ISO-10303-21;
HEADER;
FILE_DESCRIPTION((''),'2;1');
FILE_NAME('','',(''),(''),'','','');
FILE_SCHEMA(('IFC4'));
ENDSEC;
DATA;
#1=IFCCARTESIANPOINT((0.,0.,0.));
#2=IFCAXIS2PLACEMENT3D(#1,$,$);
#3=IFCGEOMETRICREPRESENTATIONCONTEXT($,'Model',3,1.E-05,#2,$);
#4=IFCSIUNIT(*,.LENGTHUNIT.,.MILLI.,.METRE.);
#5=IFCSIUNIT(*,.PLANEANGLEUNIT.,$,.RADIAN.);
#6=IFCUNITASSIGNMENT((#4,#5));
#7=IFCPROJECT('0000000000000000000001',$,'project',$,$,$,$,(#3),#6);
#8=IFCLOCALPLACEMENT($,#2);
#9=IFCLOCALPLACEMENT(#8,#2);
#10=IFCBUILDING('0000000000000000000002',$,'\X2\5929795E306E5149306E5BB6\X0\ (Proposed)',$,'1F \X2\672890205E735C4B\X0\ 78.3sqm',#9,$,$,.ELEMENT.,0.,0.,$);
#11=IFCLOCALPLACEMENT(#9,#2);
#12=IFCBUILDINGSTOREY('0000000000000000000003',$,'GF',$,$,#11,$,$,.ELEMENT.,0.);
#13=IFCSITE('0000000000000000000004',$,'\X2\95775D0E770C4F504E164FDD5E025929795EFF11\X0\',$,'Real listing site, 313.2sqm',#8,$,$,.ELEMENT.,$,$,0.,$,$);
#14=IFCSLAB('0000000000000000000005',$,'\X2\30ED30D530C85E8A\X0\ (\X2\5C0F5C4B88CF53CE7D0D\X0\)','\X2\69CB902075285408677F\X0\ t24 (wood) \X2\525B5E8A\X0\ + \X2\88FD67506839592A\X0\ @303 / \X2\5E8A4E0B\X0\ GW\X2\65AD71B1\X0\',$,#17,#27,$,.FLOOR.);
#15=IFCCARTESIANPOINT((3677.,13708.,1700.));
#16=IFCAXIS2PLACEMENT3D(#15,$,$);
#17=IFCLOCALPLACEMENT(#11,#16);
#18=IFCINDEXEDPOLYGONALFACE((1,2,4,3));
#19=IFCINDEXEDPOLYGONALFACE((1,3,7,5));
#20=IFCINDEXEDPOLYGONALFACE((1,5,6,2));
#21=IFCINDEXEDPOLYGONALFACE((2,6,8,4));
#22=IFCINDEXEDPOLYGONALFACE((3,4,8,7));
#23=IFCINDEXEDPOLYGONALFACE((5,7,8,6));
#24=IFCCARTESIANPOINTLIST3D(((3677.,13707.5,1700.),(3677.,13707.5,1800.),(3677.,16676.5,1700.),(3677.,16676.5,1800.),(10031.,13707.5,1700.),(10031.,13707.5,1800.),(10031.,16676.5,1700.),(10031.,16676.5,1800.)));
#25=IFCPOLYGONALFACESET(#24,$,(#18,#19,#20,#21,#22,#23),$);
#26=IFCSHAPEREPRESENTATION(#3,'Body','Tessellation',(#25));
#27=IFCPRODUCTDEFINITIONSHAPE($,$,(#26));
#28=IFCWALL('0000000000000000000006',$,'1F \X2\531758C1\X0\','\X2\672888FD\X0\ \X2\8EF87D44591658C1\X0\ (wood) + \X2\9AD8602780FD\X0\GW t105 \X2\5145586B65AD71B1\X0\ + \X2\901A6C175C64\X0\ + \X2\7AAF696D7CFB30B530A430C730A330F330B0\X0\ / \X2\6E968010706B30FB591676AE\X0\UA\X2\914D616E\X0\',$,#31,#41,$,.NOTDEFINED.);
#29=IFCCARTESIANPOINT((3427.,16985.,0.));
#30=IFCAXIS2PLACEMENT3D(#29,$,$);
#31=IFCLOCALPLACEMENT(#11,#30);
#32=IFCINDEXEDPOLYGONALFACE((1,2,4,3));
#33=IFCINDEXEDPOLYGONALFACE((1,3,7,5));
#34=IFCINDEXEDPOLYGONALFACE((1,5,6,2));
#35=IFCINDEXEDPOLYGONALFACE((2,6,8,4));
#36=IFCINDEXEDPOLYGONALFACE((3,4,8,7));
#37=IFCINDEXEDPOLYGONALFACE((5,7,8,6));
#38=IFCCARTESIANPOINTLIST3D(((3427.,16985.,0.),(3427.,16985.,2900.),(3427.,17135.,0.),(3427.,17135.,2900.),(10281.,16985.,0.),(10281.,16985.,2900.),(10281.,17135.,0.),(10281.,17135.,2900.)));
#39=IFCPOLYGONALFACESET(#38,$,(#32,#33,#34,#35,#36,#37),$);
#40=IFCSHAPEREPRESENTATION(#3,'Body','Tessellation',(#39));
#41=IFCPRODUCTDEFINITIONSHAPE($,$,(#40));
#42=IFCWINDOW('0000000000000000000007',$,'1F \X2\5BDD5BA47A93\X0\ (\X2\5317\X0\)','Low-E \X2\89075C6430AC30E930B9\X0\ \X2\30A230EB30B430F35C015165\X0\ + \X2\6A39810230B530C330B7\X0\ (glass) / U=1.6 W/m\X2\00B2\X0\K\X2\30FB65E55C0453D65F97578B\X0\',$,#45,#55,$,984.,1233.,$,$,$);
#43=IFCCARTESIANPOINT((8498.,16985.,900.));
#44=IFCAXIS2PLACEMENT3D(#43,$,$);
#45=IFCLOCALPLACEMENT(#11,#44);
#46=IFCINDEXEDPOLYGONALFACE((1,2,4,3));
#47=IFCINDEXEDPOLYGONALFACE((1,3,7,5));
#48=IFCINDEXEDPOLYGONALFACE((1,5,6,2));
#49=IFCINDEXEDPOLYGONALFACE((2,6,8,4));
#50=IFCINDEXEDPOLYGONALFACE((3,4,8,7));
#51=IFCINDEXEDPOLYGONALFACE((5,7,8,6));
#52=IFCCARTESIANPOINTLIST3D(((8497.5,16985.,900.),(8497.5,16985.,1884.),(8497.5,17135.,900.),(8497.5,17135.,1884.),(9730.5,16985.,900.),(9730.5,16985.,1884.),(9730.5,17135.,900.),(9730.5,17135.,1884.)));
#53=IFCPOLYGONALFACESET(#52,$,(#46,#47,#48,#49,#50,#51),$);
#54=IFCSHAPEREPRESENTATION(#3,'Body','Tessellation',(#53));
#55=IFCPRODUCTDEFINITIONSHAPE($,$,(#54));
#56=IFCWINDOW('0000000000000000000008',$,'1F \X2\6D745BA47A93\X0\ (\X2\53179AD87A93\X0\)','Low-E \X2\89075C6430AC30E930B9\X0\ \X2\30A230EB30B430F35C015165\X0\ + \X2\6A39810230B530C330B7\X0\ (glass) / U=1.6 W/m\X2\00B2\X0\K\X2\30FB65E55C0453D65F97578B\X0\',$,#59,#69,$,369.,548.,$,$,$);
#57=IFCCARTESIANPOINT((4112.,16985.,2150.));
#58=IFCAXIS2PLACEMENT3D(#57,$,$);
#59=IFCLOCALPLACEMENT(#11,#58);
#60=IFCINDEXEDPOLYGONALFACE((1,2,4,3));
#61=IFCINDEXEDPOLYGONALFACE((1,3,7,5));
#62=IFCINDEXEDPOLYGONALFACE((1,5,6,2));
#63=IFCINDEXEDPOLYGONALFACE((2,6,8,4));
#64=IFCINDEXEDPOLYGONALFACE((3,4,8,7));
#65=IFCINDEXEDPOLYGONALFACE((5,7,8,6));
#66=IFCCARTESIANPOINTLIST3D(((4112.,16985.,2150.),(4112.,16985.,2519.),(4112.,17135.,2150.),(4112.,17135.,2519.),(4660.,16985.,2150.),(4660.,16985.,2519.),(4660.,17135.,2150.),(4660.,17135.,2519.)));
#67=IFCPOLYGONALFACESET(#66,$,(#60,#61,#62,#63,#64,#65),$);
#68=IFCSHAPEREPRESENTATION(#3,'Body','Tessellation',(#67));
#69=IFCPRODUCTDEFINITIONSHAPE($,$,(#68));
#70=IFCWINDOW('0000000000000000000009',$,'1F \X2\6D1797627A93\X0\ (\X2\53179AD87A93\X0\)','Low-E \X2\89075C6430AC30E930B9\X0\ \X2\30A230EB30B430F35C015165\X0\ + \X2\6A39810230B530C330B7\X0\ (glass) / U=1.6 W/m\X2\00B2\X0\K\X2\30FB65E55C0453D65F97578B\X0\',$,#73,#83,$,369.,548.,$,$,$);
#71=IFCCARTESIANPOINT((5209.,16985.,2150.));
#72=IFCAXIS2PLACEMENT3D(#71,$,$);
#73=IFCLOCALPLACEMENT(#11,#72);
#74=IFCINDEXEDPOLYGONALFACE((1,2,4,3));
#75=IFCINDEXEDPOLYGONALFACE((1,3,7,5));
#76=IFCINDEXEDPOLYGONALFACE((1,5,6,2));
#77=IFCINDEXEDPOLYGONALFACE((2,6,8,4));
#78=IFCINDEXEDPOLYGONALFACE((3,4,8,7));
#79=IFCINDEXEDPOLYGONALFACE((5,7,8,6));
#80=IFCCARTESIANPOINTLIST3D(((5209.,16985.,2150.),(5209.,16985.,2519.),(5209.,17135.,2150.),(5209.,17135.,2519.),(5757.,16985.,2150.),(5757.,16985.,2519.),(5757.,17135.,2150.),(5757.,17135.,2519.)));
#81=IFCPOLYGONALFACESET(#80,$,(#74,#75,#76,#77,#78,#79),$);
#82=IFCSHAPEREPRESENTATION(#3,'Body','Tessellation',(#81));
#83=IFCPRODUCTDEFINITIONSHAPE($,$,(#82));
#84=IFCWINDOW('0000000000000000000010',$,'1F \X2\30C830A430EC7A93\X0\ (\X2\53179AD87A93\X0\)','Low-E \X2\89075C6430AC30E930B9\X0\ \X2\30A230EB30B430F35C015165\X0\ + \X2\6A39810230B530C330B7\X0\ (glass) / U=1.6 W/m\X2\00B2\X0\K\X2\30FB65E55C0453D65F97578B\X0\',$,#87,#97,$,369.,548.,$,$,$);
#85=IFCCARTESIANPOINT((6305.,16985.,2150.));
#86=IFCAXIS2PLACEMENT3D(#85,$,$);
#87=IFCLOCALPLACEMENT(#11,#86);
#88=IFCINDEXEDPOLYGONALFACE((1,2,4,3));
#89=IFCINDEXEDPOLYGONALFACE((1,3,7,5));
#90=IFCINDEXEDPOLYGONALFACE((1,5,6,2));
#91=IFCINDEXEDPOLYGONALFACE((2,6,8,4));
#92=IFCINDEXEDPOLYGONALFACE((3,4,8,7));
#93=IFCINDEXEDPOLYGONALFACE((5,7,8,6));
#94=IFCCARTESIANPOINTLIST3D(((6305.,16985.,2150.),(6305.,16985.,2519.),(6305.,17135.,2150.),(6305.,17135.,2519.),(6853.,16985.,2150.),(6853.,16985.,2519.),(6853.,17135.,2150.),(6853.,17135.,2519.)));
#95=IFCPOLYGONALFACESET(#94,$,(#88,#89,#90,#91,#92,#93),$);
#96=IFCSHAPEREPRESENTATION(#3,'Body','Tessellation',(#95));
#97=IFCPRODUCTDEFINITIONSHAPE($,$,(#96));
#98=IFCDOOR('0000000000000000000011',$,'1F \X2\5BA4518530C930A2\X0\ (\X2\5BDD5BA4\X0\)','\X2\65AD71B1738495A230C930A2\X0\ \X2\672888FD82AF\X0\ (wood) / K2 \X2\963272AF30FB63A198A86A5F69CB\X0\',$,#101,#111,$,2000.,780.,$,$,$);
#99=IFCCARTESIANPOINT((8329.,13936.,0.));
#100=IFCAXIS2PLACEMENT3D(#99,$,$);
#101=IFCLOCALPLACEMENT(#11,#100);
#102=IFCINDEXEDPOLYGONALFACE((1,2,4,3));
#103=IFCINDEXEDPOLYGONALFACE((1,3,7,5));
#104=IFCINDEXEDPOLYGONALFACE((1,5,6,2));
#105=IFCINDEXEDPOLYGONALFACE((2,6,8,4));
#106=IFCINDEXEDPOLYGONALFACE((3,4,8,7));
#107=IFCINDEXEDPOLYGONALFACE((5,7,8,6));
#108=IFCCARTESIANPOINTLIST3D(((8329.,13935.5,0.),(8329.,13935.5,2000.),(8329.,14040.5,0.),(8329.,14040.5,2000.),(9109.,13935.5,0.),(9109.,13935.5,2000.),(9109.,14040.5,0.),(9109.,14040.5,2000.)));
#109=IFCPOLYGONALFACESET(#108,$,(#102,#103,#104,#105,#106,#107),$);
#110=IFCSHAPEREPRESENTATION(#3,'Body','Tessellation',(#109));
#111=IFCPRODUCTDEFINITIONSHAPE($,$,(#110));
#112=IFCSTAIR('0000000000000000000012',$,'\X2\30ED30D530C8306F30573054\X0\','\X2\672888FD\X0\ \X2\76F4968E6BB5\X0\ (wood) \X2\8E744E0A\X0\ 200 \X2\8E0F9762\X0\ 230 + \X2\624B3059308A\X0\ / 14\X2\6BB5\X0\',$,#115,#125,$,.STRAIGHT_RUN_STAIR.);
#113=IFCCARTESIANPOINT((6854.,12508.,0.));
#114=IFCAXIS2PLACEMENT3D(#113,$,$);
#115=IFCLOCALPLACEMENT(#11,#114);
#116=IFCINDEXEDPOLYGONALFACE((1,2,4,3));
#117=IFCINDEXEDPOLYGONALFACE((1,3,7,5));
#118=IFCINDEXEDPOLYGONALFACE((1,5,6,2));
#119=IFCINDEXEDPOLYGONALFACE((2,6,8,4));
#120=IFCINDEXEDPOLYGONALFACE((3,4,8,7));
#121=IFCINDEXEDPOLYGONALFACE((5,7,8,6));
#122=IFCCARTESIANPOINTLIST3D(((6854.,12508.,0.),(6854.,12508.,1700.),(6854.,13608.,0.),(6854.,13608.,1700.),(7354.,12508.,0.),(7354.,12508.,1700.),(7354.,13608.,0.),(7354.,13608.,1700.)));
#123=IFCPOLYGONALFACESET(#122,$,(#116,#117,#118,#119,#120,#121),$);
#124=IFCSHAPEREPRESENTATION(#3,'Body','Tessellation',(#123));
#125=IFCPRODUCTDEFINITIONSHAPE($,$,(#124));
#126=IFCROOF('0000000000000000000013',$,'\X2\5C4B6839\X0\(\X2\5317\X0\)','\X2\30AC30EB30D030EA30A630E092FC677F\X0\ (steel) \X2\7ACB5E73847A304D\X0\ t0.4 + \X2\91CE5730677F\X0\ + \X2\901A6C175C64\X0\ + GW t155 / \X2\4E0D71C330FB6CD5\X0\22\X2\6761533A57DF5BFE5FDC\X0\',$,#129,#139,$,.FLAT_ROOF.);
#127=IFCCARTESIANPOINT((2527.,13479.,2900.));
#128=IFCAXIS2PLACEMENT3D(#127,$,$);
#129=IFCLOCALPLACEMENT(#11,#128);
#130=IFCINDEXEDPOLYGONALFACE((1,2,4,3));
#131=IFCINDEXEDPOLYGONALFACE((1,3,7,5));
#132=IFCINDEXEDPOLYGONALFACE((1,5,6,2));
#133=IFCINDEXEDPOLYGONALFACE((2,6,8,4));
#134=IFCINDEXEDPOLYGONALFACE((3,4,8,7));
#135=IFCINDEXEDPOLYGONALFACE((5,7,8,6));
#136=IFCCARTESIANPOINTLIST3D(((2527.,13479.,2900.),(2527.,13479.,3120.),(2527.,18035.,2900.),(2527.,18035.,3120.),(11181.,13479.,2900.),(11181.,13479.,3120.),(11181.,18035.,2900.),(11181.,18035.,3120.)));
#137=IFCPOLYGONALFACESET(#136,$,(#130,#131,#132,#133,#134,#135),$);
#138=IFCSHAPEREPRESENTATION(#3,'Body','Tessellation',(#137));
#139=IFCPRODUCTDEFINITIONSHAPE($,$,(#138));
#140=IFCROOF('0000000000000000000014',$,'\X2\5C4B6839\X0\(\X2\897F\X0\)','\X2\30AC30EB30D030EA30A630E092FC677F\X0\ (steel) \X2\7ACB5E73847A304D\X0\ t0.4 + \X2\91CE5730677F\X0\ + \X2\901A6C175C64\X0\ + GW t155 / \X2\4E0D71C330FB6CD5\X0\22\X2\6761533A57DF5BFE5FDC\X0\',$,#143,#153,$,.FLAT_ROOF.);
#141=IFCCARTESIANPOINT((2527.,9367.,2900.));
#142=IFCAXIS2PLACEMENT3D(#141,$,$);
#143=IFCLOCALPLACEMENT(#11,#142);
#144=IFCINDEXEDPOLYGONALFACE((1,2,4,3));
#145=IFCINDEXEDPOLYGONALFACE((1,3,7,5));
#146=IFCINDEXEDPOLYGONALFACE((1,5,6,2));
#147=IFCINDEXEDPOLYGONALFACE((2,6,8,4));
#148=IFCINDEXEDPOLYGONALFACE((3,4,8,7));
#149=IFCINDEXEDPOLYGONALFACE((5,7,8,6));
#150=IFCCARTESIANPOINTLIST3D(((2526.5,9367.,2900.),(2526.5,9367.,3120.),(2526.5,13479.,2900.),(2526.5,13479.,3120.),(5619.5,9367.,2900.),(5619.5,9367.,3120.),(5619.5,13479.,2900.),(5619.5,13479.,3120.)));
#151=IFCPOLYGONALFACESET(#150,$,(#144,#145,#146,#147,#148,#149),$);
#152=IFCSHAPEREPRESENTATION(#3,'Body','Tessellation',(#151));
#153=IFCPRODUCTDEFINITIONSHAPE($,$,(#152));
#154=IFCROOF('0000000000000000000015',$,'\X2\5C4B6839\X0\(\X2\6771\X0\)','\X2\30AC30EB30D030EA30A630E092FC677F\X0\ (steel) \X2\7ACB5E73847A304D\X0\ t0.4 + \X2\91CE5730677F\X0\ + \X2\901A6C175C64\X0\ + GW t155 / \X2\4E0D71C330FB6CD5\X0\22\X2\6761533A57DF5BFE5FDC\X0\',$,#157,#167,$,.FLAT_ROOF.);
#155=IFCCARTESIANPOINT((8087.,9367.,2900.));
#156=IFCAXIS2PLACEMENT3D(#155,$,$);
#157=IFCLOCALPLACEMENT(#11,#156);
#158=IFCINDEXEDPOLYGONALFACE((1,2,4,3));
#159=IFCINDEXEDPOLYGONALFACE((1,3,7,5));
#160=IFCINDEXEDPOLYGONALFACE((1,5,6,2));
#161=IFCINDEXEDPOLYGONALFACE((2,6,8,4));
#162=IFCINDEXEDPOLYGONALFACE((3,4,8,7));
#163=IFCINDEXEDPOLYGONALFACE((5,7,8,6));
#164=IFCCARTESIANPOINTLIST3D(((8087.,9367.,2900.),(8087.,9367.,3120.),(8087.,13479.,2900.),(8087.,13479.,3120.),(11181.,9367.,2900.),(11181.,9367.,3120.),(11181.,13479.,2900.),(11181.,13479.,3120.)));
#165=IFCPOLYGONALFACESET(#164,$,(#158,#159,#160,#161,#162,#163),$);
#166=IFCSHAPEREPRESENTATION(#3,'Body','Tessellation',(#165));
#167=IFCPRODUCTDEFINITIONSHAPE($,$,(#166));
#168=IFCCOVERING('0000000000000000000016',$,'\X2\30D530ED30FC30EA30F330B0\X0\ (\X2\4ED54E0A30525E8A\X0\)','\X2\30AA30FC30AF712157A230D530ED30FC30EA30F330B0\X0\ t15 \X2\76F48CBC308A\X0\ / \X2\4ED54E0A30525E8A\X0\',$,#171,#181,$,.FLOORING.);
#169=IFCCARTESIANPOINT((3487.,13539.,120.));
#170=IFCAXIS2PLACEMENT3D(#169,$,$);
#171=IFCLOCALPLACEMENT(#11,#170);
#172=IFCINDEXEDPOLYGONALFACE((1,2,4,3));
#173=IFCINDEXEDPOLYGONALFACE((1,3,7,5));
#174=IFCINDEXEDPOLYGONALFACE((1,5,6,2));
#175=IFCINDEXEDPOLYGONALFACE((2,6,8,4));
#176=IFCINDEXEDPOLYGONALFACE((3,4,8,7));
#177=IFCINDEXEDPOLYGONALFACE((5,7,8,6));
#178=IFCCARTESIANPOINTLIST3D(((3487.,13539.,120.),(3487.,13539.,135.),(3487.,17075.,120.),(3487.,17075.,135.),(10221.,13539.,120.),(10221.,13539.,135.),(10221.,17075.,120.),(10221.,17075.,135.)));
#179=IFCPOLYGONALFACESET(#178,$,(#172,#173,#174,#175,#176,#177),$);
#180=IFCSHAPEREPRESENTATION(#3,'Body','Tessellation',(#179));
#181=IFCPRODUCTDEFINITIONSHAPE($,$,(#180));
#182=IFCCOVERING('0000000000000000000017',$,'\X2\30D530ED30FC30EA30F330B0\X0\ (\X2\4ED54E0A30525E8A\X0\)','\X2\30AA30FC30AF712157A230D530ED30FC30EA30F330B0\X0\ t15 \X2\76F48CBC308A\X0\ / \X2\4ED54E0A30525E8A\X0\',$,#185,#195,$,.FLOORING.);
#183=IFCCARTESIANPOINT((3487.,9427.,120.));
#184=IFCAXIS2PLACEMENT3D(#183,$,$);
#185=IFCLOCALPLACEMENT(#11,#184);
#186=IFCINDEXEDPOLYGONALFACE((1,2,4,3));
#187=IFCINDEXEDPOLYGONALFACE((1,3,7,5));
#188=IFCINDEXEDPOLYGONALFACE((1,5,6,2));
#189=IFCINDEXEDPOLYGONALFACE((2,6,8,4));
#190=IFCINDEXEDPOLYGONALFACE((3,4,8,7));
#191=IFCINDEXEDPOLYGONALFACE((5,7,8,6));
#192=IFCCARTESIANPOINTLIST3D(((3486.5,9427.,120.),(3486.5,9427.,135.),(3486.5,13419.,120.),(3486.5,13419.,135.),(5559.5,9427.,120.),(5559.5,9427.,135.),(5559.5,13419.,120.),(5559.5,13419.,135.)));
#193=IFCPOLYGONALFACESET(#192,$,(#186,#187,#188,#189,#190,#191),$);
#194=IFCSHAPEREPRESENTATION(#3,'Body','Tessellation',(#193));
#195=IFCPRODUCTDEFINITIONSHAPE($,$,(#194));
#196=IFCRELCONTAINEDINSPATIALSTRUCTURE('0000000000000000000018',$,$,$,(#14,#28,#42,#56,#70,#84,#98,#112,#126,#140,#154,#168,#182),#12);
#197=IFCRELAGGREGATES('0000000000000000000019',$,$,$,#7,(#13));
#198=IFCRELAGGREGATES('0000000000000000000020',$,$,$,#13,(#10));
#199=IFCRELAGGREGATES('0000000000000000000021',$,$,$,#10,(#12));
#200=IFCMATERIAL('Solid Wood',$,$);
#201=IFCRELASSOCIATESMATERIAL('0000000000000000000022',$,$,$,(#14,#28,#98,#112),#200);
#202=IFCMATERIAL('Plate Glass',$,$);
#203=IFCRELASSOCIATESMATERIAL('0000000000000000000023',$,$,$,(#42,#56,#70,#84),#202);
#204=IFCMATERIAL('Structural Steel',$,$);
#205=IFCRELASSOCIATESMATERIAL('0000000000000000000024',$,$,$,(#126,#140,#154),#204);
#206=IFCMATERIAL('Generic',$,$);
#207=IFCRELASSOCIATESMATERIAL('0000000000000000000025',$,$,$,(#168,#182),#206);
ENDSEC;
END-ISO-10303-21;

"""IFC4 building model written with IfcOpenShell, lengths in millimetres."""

from ifc_helpers import new_model, si_unit, frame, frame_2d, origin, place, context, project, spatial, rectangle, extrude, material, element, fill, save


model = new_model("IFC4")

# Units and contexts
model_context = context("Model", 3, precision=1e-05, world=origin())
ifc_project = project(units=[si_unit("LENGTHUNIT", "METRE", prefix="MILLI"), si_unit("PLANEANGLEUNIT", "RADIAN")], contexts=[model_context])

# Site, building, storey
site_placement = place(None, origin())
site = spatial("IfcSite", under=ifc_project, at=site_placement, Name="長崎県佐世保市天神１", ObjectType="Real listing site, 313.2sqm", CompositionType="ELEMENT", RefElevation=0.0)
building_placement = place(site_placement, origin())
building = spatial("IfcBuilding", under=site, at=building_placement, Name="天神の光の家 (Proposed)", ObjectType="1F 木造平屋 78.3sqm", CompositionType="ELEMENT", ElevationOfRefHeight=0.0, ElevationOfTerrain=0.0)
storey_placement = place(building_placement, origin())
storey = spatial("IfcBuildingStorey", under=building, at=storey_placement, Name="GF", CompositionType="ELEMENT", Elevation=0.0)

# Slab
ifc_material_1 = material(Name="Solid Wood")
slab_1_placement = place(storey_placement, frame((3677.0, 13708.0, 1700.0)))
element("IfcSlab", 1, at=slab_1_placement, inside=storey, material=ifc_material_1, Name="ロフト床 (小屋裏収納)", Description="構造用合板 t24 (wood) 剛床 + 製材根太 @303 / 床下 GW断熱", PredefinedType="FLOOR", context=model_context, shape_type="SweptSolid", body=[
    extrude(rectangle(XDim=6354.0, YDim=2969.0, at=frame_2d((3177.0, 1484.0))), frame((3677.0, 13708.0, 1700.0)), (0.0, 0.0, 1.0), 100.0),
])

# Wall, openings, windows
wall_1_placement = place(storey_placement, frame((3427.0, 16985.0, 0.0)))
wall_1 = element("IfcWall", 2, at=wall_1_placement, inside=storey, material=ifc_material_1, Name="1F 北壁", Description="木製 軸組外壁 (wood) + 高性能GW t105 充填断熱 + 通気層 + 窯業系サイディング / 準耐火・外皮UA配慮", PredefinedType="NOTDEFINED", context=model_context, shape_type="SweptSolid", body=[
    extrude(rectangle(XDim=6854.0, YDim=150.0, at=frame_2d((3427.0, 75.0))), frame((3427.0, 16985.0, 0.0)), (0.0, 0.0, 1.0), 2900.0),
])
opening_1_placement = place(storey_placement, frame((8498.0, 16985.0, 900.0)))
opening_1 = element("IfcOpeningElement", 3, at=opening_1_placement, cuts=wall_1, PredefinedType="NOTDEFINED", context=model_context, shape_type="SweptSolid", body=[
    extrude(rectangle(XDim=1233.0, YDim=150.0, at=frame_2d((616.0, 75.0))), frame((8498.0, 16985.0, 900.0)), (0.0, 0.0, 1.0), 984.0),
])
opening_2_placement = place(storey_placement, frame((4112.0, 16985.0, 2150.0)))
opening_2 = element("IfcOpeningElement", 4, at=opening_2_placement, cuts=wall_1, PredefinedType="NOTDEFINED", context=model_context, shape_type="SweptSolid", body=[
    extrude(rectangle(XDim=548.0, YDim=150.0, at=frame_2d((274.0, 75.0))), frame((4112.0, 16985.0, 2150.0)), (0.0, 0.0, 1.0), 369.0),
])
opening_3_placement = place(storey_placement, frame((5209.0, 16985.0, 2150.0)))
opening_3 = element("IfcOpeningElement", 5, at=opening_3_placement, cuts=wall_1, PredefinedType="NOTDEFINED", context=model_context, shape_type="SweptSolid", body=[
    extrude(rectangle(XDim=548.0, YDim=150.0, at=frame_2d((274.0, 75.0))), frame((5209.0, 16985.0, 2150.0)), (0.0, 0.0, 1.0), 369.0),
])
opening_4_placement = place(storey_placement, frame((6305.0, 16985.0, 2150.0)))
opening_4 = element("IfcOpeningElement", 6, at=opening_4_placement, cuts=wall_1, PredefinedType="NOTDEFINED", context=model_context, shape_type="SweptSolid", body=[
    extrude(rectangle(XDim=548.0, YDim=150.0, at=frame_2d((274.0, 75.0))), frame((6305.0, 16985.0, 2150.0)), (0.0, 0.0, 1.0), 369.0),
])
ifc_material_2 = material(Name="Plate Glass")
window_1_placement = place(storey_placement, frame((8498.0, 16985.0, 900.0)))
window_1 = element("IfcWindow", 7, at=window_1_placement, inside=storey, material=ifc_material_2, Name="1F 寝室窓 (北)", Description="Low-E 複層ガラス アルゴン封入 + 樹脂サッシ (glass) / U=1.6 W/m²K・日射取得型", OverallHeight=984.0, OverallWidth=1233.0, context=model_context, shape_type="SweptSolid", body=[
    extrude(rectangle(XDim=1233.0, YDim=150.0, at=frame_2d((616.0, 75.0))), frame((8498.0, 16985.0, 900.0)), (0.0, 0.0, 1.0), 984.0),
])
fill(opening_1, window_1)
window_2_placement = place(storey_placement, frame((4112.0, 16985.0, 2150.0)))
window_2 = element("IfcWindow", 8, at=window_2_placement, inside=storey, material=ifc_material_2, Name="1F 浴室窓 (北高窓)", Description="Low-E 複層ガラス アルゴン封入 + 樹脂サッシ (glass) / U=1.6 W/m²K・日射取得型", OverallHeight=369.0, OverallWidth=548.0, context=model_context, shape_type="SweptSolid", body=[
    extrude(rectangle(XDim=548.0, YDim=150.0, at=frame_2d((274.0, 75.0))), frame((4112.0, 16985.0, 2150.0)), (0.0, 0.0, 1.0), 369.0),
])
fill(opening_2, window_2)
window_3_placement = place(storey_placement, frame((5209.0, 16985.0, 2150.0)))
window_3 = element("IfcWindow", 9, at=window_3_placement, inside=storey, material=ifc_material_2, Name="1F 洗面窓 (北高窓)", Description="Low-E 複層ガラス アルゴン封入 + 樹脂サッシ (glass) / U=1.6 W/m²K・日射取得型", OverallHeight=369.0, OverallWidth=548.0, context=model_context, shape_type="SweptSolid", body=[
    extrude(rectangle(XDim=548.0, YDim=150.0, at=frame_2d((274.0, 75.0))), frame((5209.0, 16985.0, 2150.0)), (0.0, 0.0, 1.0), 369.0),
])
fill(opening_3, window_3)
window_4_placement = place(storey_placement, frame((6305.0, 16985.0, 2150.0)))
window_4 = element("IfcWindow", 10, at=window_4_placement, inside=storey, material=ifc_material_2, Name="1F トイレ窓 (北高窓)", Description="Low-E 複層ガラス アルゴン封入 + 樹脂サッシ (glass) / U=1.6 W/m²K・日射取得型", OverallHeight=369.0, OverallWidth=548.0, context=model_context, shape_type="SweptSolid", body=[
    extrude(rectangle(XDim=548.0, YDim=150.0, at=frame_2d((274.0, 75.0))), frame((6305.0, 16985.0, 2150.0)), (0.0, 0.0, 1.0), 369.0),
])
fill(opening_4, window_4)

# Door
door_1_placement = place(storey_placement, frame((8329.0, 13936.0, 0.0)))
element("IfcDoor", 11, at=door_1_placement, inside=storey, material=ifc_material_1, Name="1F 室内ドア (寝室)", Description="断熱玄関ドア 木製芯 (wood) / K2 防犯・採風機構", OverallHeight=2000.0, OverallWidth=780.0, context=model_context, shape_type="SweptSolid", body=[
    extrude(rectangle(XDim=780.0, YDim=105.0, at=frame_2d((390.0, 52.0))), frame((8329.0, 13936.0, 0.0)), (0.0, 0.0, 1.0), 2000.0),
])

# Stair
stair_placement = place(storey_placement, frame((6854.0, 12508.0, 0.0)))
element("IfcStair", 12, at=stair_placement, inside=storey, material=ifc_material_1, Name="ロフトはしご", Description="木製 直階段 (wood) 蹴上 200 踏面 230 + 手すり / 14段", PredefinedType="STRAIGHT_RUN_STAIR", context=model_context, shape_type="SweptSolid", body=[
    extrude(rectangle(XDim=500.0, YDim=1100.0, at=frame_2d((250.0, 550.0))), frame((6854.0, 12508.0, 0.0)), (0.0, 0.0, 1.0), 1700.0),
])

# Roofs
ifc_material_3 = material(Name="Structural Steel")
roof_1_placement = place(storey_placement, frame((2527.0, 13479.0, 2900.0)))
element("IfcRoof", 13, at=roof_1_placement, inside=storey, material=ifc_material_3, Name="屋根(北)", Description="ガルバリウム鋼板 (steel) 立平葺き t0.4 + 野地板 + 通気層 + GW t155 / 不燃・法22条区域対応", PredefinedType="FLAT_ROOF", context=model_context, shape_type="SweptSolid", body=[
    extrude(rectangle(XDim=8654.0, YDim=4556.0, at=frame_2d((4327.0, 2278.0))), frame((2527.0, 13479.0, 2900.0)), (0.0, 0.0, 1.0), 220.0),
])
roof_2_placement = place(storey_placement, frame((2527.0, 9367.0, 2900.0)))
element("IfcRoof", 14, at=roof_2_placement, inside=storey, material=ifc_material_3, Name="屋根(西)", Description="ガルバリウム鋼板 (steel) 立平葺き t0.4 + 野地板 + 通気層 + GW t155 / 不燃・法22条区域対応", PredefinedType="FLAT_ROOF", context=model_context, shape_type="SweptSolid", body=[
    extrude(rectangle(XDim=3093.0, YDim=4112.0, at=frame_2d((1546.0, 2056.0))), frame((2527.0, 9367.0, 2900.0)), (0.0, 0.0, 1.0), 220.0),
])
roof_3_placement = place(storey_placement, frame((8087.0, 9367.0, 2900.0)))
element("IfcRoof", 15, at=roof_3_placement, inside=storey, material=ifc_material_3, Name="屋根(東)", Description="ガルバリウム鋼板 (steel) 立平葺き t0.4 + 野地板 + 通気層 + GW t155 / 不燃・法22条区域対応", PredefinedType="FLAT_ROOF", context=model_context, shape_type="SweptSolid", body=[
    extrude(rectangle(XDim=3094.0, YDim=4112.0, at=frame_2d((1547.0, 2056.0))), frame((8087.0, 9367.0, 2900.0)), (0.0, 0.0, 1.0), 220.0),
])

# Coverings
ifc_material_4 = material(Name="Generic")
covering_1_placement = place(storey_placement, frame((3487.0, 13539.0, 120.0)))
element("IfcCovering", 16, at=covering_1_placement, inside=storey, material=ifc_material_4, Name="フローリング (仕上げ床)", Description="オーク無垢フローリング t15 直貼り / 仕上げ床", PredefinedType="FLOORING", context=model_context, shape_type="SweptSolid", body=[
    extrude(rectangle(XDim=6734.0, YDim=3536.0, at=frame_2d((3367.0, 1768.0))), frame((3487.0, 13539.0, 120.0)), (0.0, 0.0, 1.0), 15.0),
])
covering_2_placement = place(storey_placement, frame((3487.0, 9427.0, 120.0)))
element("IfcCovering", 17, at=covering_2_placement, inside=storey, material=ifc_material_4, Name="フローリング (仕上げ床)", Description="オーク無垢フローリング t15 直貼り / 仕上げ床", PredefinedType="FLOORING", context=model_context, shape_type="SweptSolid", body=[
    extrude(rectangle(XDim=2073.0, YDim=3992.0, at=frame_2d((1036.0, 1996.0))), frame((3487.0, 9427.0, 120.0)), (0.0, 0.0, 1.0), 15.0),
])

save(model, "model.ifc")
